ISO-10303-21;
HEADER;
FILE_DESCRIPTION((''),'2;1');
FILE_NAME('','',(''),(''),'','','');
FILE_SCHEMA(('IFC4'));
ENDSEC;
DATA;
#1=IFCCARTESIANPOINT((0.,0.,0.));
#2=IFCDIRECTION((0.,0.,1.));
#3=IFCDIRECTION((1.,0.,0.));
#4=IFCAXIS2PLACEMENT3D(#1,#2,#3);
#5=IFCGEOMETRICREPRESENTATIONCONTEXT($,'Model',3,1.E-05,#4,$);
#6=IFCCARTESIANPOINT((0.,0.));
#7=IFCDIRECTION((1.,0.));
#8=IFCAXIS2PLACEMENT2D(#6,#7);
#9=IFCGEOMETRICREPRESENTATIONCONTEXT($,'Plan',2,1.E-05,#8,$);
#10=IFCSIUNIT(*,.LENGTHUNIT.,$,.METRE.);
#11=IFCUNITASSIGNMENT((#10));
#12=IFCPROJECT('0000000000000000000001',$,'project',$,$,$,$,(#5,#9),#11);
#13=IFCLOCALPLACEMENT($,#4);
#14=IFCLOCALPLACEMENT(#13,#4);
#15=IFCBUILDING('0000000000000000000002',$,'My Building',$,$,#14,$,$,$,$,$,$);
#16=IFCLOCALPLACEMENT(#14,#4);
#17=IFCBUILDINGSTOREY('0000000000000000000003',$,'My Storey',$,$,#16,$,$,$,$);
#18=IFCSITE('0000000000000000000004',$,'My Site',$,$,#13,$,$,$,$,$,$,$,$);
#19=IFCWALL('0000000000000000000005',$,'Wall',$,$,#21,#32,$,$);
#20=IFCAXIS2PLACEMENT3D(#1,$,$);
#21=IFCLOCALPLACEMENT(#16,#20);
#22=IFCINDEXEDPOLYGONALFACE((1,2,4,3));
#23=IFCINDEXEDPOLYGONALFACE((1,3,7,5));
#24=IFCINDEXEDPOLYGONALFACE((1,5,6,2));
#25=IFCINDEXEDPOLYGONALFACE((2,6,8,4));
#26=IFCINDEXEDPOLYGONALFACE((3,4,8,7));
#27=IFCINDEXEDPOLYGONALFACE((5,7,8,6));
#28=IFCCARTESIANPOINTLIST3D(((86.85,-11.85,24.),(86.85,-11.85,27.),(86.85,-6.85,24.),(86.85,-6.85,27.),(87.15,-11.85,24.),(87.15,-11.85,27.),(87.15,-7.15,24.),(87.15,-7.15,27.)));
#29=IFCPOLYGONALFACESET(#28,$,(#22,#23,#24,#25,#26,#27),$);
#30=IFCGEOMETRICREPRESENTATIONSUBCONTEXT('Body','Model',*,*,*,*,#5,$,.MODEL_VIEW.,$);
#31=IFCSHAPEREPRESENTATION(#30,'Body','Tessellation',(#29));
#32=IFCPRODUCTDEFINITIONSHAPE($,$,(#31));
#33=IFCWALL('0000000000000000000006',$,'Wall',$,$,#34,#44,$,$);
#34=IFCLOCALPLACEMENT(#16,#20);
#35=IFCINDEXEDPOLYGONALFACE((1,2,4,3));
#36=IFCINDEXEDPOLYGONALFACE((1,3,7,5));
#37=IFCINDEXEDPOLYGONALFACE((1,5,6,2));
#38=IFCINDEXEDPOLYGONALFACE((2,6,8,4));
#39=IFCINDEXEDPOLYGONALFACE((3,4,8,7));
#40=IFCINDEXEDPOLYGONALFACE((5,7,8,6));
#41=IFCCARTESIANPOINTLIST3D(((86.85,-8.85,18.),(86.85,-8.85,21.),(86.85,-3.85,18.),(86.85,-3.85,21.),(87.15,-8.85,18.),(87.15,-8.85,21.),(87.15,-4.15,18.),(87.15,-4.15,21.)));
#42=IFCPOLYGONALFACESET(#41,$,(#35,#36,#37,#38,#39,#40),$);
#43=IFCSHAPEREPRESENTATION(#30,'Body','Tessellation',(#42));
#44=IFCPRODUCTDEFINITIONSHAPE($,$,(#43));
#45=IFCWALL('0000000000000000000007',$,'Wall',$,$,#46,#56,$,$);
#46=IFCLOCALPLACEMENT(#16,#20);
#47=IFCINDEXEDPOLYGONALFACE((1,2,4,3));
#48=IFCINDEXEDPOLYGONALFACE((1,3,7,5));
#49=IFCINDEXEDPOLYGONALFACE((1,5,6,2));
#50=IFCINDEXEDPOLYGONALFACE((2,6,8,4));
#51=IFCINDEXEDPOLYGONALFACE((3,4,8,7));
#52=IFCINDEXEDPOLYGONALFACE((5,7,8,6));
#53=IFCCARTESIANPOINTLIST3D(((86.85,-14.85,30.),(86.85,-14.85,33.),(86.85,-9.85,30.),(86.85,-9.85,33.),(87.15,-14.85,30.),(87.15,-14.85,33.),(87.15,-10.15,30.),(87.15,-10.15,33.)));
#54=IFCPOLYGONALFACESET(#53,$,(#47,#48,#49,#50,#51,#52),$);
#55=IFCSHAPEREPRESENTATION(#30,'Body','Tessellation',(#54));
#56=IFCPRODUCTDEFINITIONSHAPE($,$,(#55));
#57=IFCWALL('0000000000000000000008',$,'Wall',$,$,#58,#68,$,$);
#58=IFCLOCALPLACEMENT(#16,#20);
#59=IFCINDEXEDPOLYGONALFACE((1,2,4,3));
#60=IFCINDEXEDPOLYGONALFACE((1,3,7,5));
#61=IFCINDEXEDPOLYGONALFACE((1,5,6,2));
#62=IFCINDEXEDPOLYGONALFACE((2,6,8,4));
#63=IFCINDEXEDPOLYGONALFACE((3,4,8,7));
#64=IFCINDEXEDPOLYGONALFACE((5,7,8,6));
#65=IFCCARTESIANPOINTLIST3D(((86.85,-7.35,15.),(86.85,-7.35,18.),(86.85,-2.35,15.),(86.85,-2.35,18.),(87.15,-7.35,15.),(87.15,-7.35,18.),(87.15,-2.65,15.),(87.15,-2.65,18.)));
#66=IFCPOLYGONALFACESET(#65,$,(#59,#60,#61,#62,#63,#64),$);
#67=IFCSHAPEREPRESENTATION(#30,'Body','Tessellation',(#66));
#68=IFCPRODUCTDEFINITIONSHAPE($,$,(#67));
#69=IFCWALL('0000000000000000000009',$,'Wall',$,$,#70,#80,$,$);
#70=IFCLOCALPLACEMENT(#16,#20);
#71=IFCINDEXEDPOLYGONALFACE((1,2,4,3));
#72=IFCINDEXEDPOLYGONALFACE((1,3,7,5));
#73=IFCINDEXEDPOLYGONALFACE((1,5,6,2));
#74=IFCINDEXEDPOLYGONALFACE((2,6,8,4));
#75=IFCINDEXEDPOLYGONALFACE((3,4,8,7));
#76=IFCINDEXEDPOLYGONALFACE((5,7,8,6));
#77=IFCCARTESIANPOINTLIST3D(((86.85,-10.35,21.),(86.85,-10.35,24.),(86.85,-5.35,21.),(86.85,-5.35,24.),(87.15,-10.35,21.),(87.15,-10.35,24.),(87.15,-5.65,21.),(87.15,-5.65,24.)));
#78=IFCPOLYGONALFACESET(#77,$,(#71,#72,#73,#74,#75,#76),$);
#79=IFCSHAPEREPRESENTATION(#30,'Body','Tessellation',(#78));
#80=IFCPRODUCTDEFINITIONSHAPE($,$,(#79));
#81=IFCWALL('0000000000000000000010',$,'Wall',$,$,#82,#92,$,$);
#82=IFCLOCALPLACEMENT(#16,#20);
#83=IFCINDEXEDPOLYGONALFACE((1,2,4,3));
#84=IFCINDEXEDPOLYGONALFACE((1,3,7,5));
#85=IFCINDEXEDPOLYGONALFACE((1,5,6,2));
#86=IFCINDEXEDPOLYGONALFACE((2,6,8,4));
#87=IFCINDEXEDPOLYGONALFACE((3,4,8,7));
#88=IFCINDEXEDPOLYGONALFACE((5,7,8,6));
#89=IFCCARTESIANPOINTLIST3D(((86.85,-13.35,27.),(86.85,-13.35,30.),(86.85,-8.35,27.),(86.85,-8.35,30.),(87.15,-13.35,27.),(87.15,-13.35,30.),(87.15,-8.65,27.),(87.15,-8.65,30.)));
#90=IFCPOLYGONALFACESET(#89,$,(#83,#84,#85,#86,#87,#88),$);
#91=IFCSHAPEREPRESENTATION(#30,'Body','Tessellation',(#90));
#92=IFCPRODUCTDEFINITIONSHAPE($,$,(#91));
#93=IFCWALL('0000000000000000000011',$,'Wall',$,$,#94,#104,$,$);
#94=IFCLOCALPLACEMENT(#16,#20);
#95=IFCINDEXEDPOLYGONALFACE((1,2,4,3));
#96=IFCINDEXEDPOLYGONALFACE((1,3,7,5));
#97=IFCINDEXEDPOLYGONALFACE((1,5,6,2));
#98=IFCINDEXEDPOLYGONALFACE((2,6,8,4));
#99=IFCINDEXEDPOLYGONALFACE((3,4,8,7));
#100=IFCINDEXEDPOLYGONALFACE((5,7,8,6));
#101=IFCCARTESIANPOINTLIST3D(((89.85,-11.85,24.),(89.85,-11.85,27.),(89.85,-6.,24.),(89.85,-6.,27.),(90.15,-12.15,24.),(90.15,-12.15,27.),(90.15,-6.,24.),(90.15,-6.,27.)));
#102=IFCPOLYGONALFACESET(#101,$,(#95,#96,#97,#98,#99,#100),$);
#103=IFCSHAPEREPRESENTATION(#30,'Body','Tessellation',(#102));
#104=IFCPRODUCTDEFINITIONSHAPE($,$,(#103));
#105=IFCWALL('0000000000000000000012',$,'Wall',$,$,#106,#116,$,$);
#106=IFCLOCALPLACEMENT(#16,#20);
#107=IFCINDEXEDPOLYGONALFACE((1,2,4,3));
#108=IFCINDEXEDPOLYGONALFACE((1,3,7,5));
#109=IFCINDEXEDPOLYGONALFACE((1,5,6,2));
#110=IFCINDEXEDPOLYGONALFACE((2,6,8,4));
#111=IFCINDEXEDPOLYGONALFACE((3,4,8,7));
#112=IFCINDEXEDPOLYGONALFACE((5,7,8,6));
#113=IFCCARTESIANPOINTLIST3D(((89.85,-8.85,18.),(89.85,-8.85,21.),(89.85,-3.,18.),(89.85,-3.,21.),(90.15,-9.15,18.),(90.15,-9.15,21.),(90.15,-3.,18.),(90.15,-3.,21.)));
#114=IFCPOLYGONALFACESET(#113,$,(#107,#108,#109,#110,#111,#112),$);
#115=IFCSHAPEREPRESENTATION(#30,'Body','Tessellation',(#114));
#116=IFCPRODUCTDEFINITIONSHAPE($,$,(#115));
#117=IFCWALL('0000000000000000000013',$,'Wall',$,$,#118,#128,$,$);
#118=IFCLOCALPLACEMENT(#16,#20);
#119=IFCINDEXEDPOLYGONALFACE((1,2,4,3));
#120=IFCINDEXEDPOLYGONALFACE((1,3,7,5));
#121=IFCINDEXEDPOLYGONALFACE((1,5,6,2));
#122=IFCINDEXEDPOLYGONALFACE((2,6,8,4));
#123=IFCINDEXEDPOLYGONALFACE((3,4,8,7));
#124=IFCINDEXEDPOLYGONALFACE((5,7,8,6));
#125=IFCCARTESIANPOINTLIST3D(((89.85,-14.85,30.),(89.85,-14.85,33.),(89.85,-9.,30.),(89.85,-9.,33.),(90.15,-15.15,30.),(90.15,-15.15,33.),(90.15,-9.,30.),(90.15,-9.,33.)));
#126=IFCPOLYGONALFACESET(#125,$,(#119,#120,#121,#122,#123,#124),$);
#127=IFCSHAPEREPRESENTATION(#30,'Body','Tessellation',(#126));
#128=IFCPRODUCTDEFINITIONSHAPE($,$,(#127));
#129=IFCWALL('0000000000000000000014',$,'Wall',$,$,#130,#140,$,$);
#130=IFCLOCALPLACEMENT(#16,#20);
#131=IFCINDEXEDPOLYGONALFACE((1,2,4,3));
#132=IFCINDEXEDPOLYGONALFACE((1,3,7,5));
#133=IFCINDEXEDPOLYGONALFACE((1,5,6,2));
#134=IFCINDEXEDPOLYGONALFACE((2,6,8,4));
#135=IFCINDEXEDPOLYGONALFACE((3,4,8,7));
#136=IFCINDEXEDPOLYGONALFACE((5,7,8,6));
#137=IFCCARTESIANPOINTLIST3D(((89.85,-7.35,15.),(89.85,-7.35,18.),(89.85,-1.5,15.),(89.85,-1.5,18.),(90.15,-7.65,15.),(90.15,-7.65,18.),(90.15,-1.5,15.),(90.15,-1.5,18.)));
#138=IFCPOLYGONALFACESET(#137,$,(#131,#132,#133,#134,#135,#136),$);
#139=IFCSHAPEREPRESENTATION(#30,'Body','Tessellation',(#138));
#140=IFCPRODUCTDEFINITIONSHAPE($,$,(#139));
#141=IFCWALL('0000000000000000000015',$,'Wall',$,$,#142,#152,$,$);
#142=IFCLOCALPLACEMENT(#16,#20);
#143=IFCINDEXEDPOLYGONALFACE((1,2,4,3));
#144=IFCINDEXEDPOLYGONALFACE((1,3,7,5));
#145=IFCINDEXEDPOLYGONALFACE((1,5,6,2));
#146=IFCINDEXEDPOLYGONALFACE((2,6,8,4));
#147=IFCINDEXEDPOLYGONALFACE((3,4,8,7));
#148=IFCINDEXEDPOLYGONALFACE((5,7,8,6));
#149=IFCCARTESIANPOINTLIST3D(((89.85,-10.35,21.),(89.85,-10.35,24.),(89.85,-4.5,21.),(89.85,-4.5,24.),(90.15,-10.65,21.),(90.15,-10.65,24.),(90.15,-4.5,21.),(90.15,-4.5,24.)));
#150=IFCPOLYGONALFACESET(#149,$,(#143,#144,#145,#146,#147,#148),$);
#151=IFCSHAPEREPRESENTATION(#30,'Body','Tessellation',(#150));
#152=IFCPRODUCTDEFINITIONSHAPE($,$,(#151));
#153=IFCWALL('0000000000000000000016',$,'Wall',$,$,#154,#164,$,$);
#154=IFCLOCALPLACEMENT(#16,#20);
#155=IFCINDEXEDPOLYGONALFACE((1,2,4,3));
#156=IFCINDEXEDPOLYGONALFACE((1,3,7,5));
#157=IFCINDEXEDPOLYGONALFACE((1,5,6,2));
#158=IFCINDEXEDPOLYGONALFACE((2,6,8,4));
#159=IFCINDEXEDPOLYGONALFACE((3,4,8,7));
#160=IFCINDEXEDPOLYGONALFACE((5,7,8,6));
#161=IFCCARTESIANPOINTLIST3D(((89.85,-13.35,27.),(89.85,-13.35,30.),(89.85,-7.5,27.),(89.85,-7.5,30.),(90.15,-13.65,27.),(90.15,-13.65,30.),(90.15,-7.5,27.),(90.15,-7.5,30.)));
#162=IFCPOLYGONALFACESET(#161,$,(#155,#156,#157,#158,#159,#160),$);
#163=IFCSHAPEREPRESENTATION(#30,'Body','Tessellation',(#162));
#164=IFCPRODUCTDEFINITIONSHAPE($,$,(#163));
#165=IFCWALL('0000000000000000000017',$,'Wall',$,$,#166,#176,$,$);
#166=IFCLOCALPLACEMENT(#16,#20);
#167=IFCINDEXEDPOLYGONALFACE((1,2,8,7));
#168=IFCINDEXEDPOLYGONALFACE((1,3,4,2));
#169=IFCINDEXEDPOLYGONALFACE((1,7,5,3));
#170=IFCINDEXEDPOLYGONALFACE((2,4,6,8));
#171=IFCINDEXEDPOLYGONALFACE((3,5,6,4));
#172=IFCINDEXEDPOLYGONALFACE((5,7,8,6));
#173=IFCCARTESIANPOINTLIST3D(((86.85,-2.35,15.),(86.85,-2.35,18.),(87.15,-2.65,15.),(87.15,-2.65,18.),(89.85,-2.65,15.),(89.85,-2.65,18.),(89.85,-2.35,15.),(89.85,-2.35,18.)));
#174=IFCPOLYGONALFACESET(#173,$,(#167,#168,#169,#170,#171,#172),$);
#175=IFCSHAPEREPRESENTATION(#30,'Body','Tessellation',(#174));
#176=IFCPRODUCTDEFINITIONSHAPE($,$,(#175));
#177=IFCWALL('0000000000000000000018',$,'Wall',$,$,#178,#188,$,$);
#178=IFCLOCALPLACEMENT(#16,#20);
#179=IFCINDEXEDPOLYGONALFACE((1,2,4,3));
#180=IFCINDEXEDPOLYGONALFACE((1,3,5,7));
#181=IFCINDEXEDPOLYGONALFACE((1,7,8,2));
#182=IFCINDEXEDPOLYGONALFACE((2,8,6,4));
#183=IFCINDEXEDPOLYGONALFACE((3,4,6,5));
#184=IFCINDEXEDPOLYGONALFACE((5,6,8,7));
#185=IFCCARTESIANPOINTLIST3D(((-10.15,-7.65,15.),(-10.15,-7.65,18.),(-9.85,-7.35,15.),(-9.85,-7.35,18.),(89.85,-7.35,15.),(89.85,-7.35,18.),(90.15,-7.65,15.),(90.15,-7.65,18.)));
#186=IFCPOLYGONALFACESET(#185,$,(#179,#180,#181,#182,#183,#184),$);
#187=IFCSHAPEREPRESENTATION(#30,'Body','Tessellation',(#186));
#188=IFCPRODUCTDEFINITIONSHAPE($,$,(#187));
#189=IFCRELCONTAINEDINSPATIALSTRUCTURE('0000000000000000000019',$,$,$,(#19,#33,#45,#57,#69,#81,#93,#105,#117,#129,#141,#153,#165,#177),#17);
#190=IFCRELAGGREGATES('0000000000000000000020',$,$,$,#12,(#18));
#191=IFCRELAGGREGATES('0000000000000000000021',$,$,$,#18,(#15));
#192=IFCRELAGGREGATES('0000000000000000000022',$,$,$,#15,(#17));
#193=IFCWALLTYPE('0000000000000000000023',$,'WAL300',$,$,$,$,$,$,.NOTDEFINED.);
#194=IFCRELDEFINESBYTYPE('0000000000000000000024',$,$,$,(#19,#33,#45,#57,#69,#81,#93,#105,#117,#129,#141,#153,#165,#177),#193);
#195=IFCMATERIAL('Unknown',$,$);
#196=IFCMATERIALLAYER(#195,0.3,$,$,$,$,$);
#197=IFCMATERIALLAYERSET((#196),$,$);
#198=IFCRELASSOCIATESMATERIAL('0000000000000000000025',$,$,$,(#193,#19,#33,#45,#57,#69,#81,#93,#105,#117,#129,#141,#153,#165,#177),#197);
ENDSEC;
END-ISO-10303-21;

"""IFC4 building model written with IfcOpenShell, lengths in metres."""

from ifc_helpers import new_model, si_unit, frame, origin_with_axes, origin_2d_with_axis, place, context, subcontext, project, spatial, line, indexed_curve, outline, extrude, material, layer, layer_set, layer_usage, type_object, element, save


model = new_model("IFC4")

# Units and contexts
model_context = context("Model", 3, precision=1e-05, world=origin_with_axes())
plan_context = context("Plan", 2, precision=1e-05, world=origin_2d_with_axis())
body_context = subcontext(model_context, "Body", "Model", "MODEL_VIEW")
ifc_project = project(units=[si_unit("LENGTHUNIT", "METRE")], contexts=[model_context, plan_context])

# Site, building, storey
site_placement = place(None, origin_with_axes())
site = spatial("IfcSite", under=ifc_project, at=site_placement, Name="My Site")
building_placement = place(site_placement, origin_with_axes())
building = spatial("IfcBuilding", under=site, at=building_placement, Name="My Building")
storey_placement = place(building_placement, origin_with_axes())
storey = spatial("IfcBuildingStorey", under=building, at=storey_placement, Name="My Storey")

# Walls
ifc_material = material(Name="Unknown")
ifc_layer = layer(ifc_material, 0.3)
ifc_layer_set = layer_set([ifc_layer])
ifc_layer_usage_1 = layer_usage(ifc_layer_set, "AXIS2", "POSITIVE", -0.15)
wall_type = type_object("IfcWallType", Name="WAL300", PredefinedType="NOTDEFINED", material=ifc_layer_set)
wall_1_placement = place(storey_placement, frame((87.0, -7.0, 24.0), z_axis=(0.0, 0.0, 1.0), x_axis=(0.0, -1.0, 0.0)))
element("IfcWall", 1, at=wall_1_placement, inside=storey, type_object=wall_type, material=ifc_layer_usage_1, Name="Wall", context=body_context, shape_type="SweptSolid", body=[
    extrude(outline(indexed_curve([(-0.15, -0.15), (0.15, 0.15), (4.85, 0.15), (4.85, -0.15)], segments=[line(1, 2, 3, 4, 1)])), origin_with_axes(), (0.0, 0.0, 1.0), 3.0),
])
ifc_layer_usage_2 = layer_usage(ifc_layer_set, "AXIS2", "POSITIVE", -0.15)
wall_2_placement = place(storey_placement, frame((87.0, -4.0, 18.0), z_axis=(0.0, 0.0, 1.0), x_axis=(0.0, -1.0, 0.0)))
element("IfcWall", 2, at=wall_2_placement, inside=storey, type_object=wall_type, material=ifc_layer_usage_2, Name="Wall", context=body_context, shape_type="SweptSolid", body=[
    extrude(outline(indexed_curve([(-0.15, -0.15), (0.15, 0.15), (4.85, 0.15), (4.85, -0.15)], segments=[line(1, 2, 3, 4, 1)])), origin_with_axes(), (0.0, 0.0, 1.0), 3.0),
])
ifc_layer_usage_3 = layer_usage(ifc_layer_set, "AXIS2", "POSITIVE", -0.15)
wall_3_placement = place(storey_placement, frame((87.0, -10.0, 30.0), z_axis=(0.0, 0.0, 1.0), x_axis=(0.0, -1.0, 0.0)))
element("IfcWall", 3, at=wall_3_placement, inside=storey, type_object=wall_type, material=ifc_layer_usage_3, Name="Wall", context=body_context, shape_type="SweptSolid", body=[
    extrude(outline(indexed_curve([(-0.15, -0.15), (0.15, 0.15), (4.85, 0.15), (4.85, -0.15)], segments=[line(1, 2, 3, 4, 1)])), origin_with_axes(), (0.0, 0.0, 1.0), 3.0),
])
ifc_layer_usage_4 = layer_usage(ifc_layer_set, "AXIS2", "POSITIVE", -0.15)
wall_4_placement = place(storey_placement, frame((87.0, -2.5, 15.0), z_axis=(0.0, 0.0, 1.0), x_axis=(0.0, -1.0, 0.0)))
element("IfcWall", 4, at=wall_4_placement, inside=storey, type_object=wall_type, material=ifc_layer_usage_4, Name="Wall", context=body_context, shape_type="SweptSolid", body=[
    extrude(outline(indexed_curve([(-0.15, -0.15), (0.15, 0.15), (4.85, 0.15), (4.85, -0.15)], segments=[line(1, 2, 3, 4, 1)])), origin_with_axes(), (0.0, 0.0, 1.0), 3.0),
])
ifc_layer_usage_5 = layer_usage(ifc_layer_set, "AXIS2", "POSITIVE", -0.15)
wall_5_placement = place(storey_placement, frame((87.0, -5.5, 21.0), z_axis=(0.0, 0.0, 1.0), x_axis=(0.0, -1.0, 0.0)))
element("IfcWall", 5, at=wall_5_placement, inside=storey, type_object=wall_type, material=ifc_layer_usage_5, Name="Wall", context=body_context, shape_type="SweptSolid", body=[
    extrude(outline(indexed_curve([(-0.15, -0.15), (0.15, 0.15), (4.85, 0.15), (4.85, -0.15)], segments=[line(1, 2, 3, 4, 1)])), origin_with_axes(), (0.0, 0.0, 1.0), 3.0),
])
ifc_layer_usage_6 = layer_usage(ifc_layer_set, "AXIS2", "POSITIVE", -0.15)
wall_6_placement = place(storey_placement, frame((87.0, -8.5, 27.0), z_axis=(0.0, 0.0, 1.0), x_axis=(0.0, -1.0, 0.0)))
element("IfcWall", 6, at=wall_6_placement, inside=storey, type_object=wall_type, material=ifc_layer_usage_6, Name="Wall", context=body_context, shape_type="SweptSolid", body=[
    extrude(outline(indexed_curve([(-0.15, -0.15), (0.15, 0.15), (4.85, 0.15), (4.85, -0.15)], segments=[line(1, 2, 3, 4, 1)])), origin_with_axes(), (0.0, 0.0, 1.0), 3.0),
])
ifc_layer_usage_7 = layer_usage(ifc_layer_set, "AXIS2", "POSITIVE", -0.15)
wall_7_placement = place(storey_placement, frame((90.0, -6.0, 24.0), z_axis=(0.0, 0.0, 1.0), x_axis=(0.0, -1.0, 0.0)))
element("IfcWall", 7, at=wall_7_placement, inside=storey, type_object=wall_type, material=ifc_layer_usage_7, Name="Wall", context=body_context, shape_type="SweptSolid", body=[
    extrude(outline(indexed_curve([(0.0, -0.15), (0.0, 0.15), (6.15, 0.15), (5.85, -0.15)], segments=[line(1, 2, 3, 4, 1)])), origin_with_axes(), (0.0, 0.0, 1.0), 3.0),
])
ifc_layer_usage_8 = layer_usage(ifc_layer_set, "AXIS2", "POSITIVE", -0.15)
wall_8_placement = place(storey_placement, frame((90.0, -3.0, 18.0), z_axis=(0.0, 0.0, 1.0), x_axis=(0.0, -1.0, 0.0)))
element("IfcWall", 8, at=wall_8_placement, inside=storey, type_object=wall_type, material=ifc_layer_usage_8, Name="Wall", context=body_context, shape_type="SweptSolid", body=[
    extrude(outline(indexed_curve([(0.0, -0.15), (0.0, 0.15), (6.15, 0.15), (5.85, -0.15)], segments=[line(1, 2, 3, 4, 1)])), origin_with_axes(), (0.0, 0.0, 1.0), 3.0),
])
ifc_layer_usage_9 = layer_usage(ifc_layer_set, "AXIS2", "POSITIVE", -0.15)
wall_9_placement = place(storey_placement, frame((90.0, -9.0, 30.0), z_axis=(0.0, 0.0, 1.0), x_axis=(0.0, -1.0, 0.0)))
element("IfcWall", 9, at=wall_9_placement, inside=storey, type_object=wall_type, material=ifc_layer_usage_9, Name="Wall", context=body_context, shape_type="SweptSolid", body=[
    extrude(outline(indexed_curve([(0.0, -0.15), (0.0, 0.15), (6.15, 0.15), (5.85, -0.15)], segments=[line(1, 2, 3, 4, 1)])), origin_with_axes(), (0.0, 0.0, 1.0), 3.0),
])
ifc_layer_usage_10 = layer_usage(ifc_layer_set, "AXIS2", "POSITIVE", -0.15)
wall_10_placement = place(storey_placement, frame((90.0, -1.5, 15.0), z_axis=(0.0, 0.0, 1.0), x_axis=(0.0, -1.0, 0.0)))
element("IfcWall", 10, at=wall_10_placement, inside=storey, type_object=wall_type, material=ifc_layer_usage_10, Name="Wall", context=body_context, shape_type="SweptSolid", body=[
    extrude(outline(indexed_curve([(0.0, -0.15), (0.0, 0.15), (6.15, 0.15), (5.85, -0.15)], segments=[line(1, 2, 3, 4, 1)])), origin_with_axes(), (0.0, 0.0, 1.0), 3.0),
])
ifc_layer_usage_11 = layer_usage(ifc_layer_set, "AXIS2", "POSITIVE", -0.15)
wall_11_placement = place(storey_placement, frame((90.0, -4.5, 21.0), z_axis=(0.0, 0.0, 1.0), x_axis=(0.0, -1.0, 0.0)))
element("IfcWall", 11, at=wall_11_placement, inside=storey, type_object=wall_type, material=ifc_layer_usage_11, Name="Wall", context=body_context, shape_type="SweptSolid", body=[
    extrude(outline(indexed_curve([(0.0, -0.15), (0.0, 0.15), (6.15, 0.15), (5.85, -0.15)], segments=[line(1, 2, 3, 4, 1)])), origin_with_axes(), (0.0, 0.0, 1.0), 3.0),
])
ifc_layer_usage_12 = layer_usage(ifc_layer_set, "AXIS2", "POSITIVE", -0.15)
wall_12_placement = place(storey_placement, frame((90.0, -7.5, 27.0), z_axis=(0.0, 0.0, 1.0), x_axis=(0.0, -1.0, 0.0)))
element("IfcWall", 12, at=wall_12_placement, inside=storey, type_object=wall_type, material=ifc_layer_usage_12, Name="Wall", context=body_context, shape_type="SweptSolid", body=[
    extrude(outline(indexed_curve([(0.0, -0.15), (0.0, 0.15), (6.15, 0.15), (5.85, -0.15)], segments=[line(1, 2, 3, 4, 1)])), origin_with_axes(), (0.0, 0.0, 1.0), 3.0),
])
ifc_layer_usage_13 = layer_usage(ifc_layer_set, "AXIS2", "POSITIVE", -0.15)
wall_13_placement = place(storey_placement, frame((87.0, -2.5, 15.0), z_axis=(0.0, 0.0, 1.0), x_axis=(1.0, 0.0, 0.0)))
element("IfcWall", 13, at=wall_13_placement, inside=storey, type_object=wall_type, material=ifc_layer_usage_13, Name="Wall", context=body_context, shape_type="SweptSolid", body=[
    extrude(outline(indexed_curve([(0.15, -0.15), (-0.15, 0.15), (2.85, 0.15), (2.85, -0.15)], segments=[line(1, 2, 3, 4, 1)])), origin_with_axes(), (0.0, 0.0, 1.0), 3.0),
])
ifc_layer_usage_14 = layer_usage(ifc_layer_set, "AXIS2", "POSITIVE", -0.15)
wall_14_placement = place(storey_placement, frame((90.0, -7.5, 15.0), z_axis=(0.0, 0.0, 1.0), x_axis=(-1.0, 0.0, 0.0)))
element("IfcWall", 14, at=wall_14_placement, inside=storey, type_object=wall_type, material=ifc_layer_usage_14, Name="Wall", context=body_context, shape_type="SweptSolid", body=[
    extrude(outline(indexed_curve([(0.15, -0.15), (-0.15, 0.15), (100.15, 0.15), (99.85, -0.15)], segments=[line(1, 2, 3, 4, 1)])), origin_with_axes(), (0.0, 0.0, 1.0), 3.0),
])

save(model, "model.ifc")
